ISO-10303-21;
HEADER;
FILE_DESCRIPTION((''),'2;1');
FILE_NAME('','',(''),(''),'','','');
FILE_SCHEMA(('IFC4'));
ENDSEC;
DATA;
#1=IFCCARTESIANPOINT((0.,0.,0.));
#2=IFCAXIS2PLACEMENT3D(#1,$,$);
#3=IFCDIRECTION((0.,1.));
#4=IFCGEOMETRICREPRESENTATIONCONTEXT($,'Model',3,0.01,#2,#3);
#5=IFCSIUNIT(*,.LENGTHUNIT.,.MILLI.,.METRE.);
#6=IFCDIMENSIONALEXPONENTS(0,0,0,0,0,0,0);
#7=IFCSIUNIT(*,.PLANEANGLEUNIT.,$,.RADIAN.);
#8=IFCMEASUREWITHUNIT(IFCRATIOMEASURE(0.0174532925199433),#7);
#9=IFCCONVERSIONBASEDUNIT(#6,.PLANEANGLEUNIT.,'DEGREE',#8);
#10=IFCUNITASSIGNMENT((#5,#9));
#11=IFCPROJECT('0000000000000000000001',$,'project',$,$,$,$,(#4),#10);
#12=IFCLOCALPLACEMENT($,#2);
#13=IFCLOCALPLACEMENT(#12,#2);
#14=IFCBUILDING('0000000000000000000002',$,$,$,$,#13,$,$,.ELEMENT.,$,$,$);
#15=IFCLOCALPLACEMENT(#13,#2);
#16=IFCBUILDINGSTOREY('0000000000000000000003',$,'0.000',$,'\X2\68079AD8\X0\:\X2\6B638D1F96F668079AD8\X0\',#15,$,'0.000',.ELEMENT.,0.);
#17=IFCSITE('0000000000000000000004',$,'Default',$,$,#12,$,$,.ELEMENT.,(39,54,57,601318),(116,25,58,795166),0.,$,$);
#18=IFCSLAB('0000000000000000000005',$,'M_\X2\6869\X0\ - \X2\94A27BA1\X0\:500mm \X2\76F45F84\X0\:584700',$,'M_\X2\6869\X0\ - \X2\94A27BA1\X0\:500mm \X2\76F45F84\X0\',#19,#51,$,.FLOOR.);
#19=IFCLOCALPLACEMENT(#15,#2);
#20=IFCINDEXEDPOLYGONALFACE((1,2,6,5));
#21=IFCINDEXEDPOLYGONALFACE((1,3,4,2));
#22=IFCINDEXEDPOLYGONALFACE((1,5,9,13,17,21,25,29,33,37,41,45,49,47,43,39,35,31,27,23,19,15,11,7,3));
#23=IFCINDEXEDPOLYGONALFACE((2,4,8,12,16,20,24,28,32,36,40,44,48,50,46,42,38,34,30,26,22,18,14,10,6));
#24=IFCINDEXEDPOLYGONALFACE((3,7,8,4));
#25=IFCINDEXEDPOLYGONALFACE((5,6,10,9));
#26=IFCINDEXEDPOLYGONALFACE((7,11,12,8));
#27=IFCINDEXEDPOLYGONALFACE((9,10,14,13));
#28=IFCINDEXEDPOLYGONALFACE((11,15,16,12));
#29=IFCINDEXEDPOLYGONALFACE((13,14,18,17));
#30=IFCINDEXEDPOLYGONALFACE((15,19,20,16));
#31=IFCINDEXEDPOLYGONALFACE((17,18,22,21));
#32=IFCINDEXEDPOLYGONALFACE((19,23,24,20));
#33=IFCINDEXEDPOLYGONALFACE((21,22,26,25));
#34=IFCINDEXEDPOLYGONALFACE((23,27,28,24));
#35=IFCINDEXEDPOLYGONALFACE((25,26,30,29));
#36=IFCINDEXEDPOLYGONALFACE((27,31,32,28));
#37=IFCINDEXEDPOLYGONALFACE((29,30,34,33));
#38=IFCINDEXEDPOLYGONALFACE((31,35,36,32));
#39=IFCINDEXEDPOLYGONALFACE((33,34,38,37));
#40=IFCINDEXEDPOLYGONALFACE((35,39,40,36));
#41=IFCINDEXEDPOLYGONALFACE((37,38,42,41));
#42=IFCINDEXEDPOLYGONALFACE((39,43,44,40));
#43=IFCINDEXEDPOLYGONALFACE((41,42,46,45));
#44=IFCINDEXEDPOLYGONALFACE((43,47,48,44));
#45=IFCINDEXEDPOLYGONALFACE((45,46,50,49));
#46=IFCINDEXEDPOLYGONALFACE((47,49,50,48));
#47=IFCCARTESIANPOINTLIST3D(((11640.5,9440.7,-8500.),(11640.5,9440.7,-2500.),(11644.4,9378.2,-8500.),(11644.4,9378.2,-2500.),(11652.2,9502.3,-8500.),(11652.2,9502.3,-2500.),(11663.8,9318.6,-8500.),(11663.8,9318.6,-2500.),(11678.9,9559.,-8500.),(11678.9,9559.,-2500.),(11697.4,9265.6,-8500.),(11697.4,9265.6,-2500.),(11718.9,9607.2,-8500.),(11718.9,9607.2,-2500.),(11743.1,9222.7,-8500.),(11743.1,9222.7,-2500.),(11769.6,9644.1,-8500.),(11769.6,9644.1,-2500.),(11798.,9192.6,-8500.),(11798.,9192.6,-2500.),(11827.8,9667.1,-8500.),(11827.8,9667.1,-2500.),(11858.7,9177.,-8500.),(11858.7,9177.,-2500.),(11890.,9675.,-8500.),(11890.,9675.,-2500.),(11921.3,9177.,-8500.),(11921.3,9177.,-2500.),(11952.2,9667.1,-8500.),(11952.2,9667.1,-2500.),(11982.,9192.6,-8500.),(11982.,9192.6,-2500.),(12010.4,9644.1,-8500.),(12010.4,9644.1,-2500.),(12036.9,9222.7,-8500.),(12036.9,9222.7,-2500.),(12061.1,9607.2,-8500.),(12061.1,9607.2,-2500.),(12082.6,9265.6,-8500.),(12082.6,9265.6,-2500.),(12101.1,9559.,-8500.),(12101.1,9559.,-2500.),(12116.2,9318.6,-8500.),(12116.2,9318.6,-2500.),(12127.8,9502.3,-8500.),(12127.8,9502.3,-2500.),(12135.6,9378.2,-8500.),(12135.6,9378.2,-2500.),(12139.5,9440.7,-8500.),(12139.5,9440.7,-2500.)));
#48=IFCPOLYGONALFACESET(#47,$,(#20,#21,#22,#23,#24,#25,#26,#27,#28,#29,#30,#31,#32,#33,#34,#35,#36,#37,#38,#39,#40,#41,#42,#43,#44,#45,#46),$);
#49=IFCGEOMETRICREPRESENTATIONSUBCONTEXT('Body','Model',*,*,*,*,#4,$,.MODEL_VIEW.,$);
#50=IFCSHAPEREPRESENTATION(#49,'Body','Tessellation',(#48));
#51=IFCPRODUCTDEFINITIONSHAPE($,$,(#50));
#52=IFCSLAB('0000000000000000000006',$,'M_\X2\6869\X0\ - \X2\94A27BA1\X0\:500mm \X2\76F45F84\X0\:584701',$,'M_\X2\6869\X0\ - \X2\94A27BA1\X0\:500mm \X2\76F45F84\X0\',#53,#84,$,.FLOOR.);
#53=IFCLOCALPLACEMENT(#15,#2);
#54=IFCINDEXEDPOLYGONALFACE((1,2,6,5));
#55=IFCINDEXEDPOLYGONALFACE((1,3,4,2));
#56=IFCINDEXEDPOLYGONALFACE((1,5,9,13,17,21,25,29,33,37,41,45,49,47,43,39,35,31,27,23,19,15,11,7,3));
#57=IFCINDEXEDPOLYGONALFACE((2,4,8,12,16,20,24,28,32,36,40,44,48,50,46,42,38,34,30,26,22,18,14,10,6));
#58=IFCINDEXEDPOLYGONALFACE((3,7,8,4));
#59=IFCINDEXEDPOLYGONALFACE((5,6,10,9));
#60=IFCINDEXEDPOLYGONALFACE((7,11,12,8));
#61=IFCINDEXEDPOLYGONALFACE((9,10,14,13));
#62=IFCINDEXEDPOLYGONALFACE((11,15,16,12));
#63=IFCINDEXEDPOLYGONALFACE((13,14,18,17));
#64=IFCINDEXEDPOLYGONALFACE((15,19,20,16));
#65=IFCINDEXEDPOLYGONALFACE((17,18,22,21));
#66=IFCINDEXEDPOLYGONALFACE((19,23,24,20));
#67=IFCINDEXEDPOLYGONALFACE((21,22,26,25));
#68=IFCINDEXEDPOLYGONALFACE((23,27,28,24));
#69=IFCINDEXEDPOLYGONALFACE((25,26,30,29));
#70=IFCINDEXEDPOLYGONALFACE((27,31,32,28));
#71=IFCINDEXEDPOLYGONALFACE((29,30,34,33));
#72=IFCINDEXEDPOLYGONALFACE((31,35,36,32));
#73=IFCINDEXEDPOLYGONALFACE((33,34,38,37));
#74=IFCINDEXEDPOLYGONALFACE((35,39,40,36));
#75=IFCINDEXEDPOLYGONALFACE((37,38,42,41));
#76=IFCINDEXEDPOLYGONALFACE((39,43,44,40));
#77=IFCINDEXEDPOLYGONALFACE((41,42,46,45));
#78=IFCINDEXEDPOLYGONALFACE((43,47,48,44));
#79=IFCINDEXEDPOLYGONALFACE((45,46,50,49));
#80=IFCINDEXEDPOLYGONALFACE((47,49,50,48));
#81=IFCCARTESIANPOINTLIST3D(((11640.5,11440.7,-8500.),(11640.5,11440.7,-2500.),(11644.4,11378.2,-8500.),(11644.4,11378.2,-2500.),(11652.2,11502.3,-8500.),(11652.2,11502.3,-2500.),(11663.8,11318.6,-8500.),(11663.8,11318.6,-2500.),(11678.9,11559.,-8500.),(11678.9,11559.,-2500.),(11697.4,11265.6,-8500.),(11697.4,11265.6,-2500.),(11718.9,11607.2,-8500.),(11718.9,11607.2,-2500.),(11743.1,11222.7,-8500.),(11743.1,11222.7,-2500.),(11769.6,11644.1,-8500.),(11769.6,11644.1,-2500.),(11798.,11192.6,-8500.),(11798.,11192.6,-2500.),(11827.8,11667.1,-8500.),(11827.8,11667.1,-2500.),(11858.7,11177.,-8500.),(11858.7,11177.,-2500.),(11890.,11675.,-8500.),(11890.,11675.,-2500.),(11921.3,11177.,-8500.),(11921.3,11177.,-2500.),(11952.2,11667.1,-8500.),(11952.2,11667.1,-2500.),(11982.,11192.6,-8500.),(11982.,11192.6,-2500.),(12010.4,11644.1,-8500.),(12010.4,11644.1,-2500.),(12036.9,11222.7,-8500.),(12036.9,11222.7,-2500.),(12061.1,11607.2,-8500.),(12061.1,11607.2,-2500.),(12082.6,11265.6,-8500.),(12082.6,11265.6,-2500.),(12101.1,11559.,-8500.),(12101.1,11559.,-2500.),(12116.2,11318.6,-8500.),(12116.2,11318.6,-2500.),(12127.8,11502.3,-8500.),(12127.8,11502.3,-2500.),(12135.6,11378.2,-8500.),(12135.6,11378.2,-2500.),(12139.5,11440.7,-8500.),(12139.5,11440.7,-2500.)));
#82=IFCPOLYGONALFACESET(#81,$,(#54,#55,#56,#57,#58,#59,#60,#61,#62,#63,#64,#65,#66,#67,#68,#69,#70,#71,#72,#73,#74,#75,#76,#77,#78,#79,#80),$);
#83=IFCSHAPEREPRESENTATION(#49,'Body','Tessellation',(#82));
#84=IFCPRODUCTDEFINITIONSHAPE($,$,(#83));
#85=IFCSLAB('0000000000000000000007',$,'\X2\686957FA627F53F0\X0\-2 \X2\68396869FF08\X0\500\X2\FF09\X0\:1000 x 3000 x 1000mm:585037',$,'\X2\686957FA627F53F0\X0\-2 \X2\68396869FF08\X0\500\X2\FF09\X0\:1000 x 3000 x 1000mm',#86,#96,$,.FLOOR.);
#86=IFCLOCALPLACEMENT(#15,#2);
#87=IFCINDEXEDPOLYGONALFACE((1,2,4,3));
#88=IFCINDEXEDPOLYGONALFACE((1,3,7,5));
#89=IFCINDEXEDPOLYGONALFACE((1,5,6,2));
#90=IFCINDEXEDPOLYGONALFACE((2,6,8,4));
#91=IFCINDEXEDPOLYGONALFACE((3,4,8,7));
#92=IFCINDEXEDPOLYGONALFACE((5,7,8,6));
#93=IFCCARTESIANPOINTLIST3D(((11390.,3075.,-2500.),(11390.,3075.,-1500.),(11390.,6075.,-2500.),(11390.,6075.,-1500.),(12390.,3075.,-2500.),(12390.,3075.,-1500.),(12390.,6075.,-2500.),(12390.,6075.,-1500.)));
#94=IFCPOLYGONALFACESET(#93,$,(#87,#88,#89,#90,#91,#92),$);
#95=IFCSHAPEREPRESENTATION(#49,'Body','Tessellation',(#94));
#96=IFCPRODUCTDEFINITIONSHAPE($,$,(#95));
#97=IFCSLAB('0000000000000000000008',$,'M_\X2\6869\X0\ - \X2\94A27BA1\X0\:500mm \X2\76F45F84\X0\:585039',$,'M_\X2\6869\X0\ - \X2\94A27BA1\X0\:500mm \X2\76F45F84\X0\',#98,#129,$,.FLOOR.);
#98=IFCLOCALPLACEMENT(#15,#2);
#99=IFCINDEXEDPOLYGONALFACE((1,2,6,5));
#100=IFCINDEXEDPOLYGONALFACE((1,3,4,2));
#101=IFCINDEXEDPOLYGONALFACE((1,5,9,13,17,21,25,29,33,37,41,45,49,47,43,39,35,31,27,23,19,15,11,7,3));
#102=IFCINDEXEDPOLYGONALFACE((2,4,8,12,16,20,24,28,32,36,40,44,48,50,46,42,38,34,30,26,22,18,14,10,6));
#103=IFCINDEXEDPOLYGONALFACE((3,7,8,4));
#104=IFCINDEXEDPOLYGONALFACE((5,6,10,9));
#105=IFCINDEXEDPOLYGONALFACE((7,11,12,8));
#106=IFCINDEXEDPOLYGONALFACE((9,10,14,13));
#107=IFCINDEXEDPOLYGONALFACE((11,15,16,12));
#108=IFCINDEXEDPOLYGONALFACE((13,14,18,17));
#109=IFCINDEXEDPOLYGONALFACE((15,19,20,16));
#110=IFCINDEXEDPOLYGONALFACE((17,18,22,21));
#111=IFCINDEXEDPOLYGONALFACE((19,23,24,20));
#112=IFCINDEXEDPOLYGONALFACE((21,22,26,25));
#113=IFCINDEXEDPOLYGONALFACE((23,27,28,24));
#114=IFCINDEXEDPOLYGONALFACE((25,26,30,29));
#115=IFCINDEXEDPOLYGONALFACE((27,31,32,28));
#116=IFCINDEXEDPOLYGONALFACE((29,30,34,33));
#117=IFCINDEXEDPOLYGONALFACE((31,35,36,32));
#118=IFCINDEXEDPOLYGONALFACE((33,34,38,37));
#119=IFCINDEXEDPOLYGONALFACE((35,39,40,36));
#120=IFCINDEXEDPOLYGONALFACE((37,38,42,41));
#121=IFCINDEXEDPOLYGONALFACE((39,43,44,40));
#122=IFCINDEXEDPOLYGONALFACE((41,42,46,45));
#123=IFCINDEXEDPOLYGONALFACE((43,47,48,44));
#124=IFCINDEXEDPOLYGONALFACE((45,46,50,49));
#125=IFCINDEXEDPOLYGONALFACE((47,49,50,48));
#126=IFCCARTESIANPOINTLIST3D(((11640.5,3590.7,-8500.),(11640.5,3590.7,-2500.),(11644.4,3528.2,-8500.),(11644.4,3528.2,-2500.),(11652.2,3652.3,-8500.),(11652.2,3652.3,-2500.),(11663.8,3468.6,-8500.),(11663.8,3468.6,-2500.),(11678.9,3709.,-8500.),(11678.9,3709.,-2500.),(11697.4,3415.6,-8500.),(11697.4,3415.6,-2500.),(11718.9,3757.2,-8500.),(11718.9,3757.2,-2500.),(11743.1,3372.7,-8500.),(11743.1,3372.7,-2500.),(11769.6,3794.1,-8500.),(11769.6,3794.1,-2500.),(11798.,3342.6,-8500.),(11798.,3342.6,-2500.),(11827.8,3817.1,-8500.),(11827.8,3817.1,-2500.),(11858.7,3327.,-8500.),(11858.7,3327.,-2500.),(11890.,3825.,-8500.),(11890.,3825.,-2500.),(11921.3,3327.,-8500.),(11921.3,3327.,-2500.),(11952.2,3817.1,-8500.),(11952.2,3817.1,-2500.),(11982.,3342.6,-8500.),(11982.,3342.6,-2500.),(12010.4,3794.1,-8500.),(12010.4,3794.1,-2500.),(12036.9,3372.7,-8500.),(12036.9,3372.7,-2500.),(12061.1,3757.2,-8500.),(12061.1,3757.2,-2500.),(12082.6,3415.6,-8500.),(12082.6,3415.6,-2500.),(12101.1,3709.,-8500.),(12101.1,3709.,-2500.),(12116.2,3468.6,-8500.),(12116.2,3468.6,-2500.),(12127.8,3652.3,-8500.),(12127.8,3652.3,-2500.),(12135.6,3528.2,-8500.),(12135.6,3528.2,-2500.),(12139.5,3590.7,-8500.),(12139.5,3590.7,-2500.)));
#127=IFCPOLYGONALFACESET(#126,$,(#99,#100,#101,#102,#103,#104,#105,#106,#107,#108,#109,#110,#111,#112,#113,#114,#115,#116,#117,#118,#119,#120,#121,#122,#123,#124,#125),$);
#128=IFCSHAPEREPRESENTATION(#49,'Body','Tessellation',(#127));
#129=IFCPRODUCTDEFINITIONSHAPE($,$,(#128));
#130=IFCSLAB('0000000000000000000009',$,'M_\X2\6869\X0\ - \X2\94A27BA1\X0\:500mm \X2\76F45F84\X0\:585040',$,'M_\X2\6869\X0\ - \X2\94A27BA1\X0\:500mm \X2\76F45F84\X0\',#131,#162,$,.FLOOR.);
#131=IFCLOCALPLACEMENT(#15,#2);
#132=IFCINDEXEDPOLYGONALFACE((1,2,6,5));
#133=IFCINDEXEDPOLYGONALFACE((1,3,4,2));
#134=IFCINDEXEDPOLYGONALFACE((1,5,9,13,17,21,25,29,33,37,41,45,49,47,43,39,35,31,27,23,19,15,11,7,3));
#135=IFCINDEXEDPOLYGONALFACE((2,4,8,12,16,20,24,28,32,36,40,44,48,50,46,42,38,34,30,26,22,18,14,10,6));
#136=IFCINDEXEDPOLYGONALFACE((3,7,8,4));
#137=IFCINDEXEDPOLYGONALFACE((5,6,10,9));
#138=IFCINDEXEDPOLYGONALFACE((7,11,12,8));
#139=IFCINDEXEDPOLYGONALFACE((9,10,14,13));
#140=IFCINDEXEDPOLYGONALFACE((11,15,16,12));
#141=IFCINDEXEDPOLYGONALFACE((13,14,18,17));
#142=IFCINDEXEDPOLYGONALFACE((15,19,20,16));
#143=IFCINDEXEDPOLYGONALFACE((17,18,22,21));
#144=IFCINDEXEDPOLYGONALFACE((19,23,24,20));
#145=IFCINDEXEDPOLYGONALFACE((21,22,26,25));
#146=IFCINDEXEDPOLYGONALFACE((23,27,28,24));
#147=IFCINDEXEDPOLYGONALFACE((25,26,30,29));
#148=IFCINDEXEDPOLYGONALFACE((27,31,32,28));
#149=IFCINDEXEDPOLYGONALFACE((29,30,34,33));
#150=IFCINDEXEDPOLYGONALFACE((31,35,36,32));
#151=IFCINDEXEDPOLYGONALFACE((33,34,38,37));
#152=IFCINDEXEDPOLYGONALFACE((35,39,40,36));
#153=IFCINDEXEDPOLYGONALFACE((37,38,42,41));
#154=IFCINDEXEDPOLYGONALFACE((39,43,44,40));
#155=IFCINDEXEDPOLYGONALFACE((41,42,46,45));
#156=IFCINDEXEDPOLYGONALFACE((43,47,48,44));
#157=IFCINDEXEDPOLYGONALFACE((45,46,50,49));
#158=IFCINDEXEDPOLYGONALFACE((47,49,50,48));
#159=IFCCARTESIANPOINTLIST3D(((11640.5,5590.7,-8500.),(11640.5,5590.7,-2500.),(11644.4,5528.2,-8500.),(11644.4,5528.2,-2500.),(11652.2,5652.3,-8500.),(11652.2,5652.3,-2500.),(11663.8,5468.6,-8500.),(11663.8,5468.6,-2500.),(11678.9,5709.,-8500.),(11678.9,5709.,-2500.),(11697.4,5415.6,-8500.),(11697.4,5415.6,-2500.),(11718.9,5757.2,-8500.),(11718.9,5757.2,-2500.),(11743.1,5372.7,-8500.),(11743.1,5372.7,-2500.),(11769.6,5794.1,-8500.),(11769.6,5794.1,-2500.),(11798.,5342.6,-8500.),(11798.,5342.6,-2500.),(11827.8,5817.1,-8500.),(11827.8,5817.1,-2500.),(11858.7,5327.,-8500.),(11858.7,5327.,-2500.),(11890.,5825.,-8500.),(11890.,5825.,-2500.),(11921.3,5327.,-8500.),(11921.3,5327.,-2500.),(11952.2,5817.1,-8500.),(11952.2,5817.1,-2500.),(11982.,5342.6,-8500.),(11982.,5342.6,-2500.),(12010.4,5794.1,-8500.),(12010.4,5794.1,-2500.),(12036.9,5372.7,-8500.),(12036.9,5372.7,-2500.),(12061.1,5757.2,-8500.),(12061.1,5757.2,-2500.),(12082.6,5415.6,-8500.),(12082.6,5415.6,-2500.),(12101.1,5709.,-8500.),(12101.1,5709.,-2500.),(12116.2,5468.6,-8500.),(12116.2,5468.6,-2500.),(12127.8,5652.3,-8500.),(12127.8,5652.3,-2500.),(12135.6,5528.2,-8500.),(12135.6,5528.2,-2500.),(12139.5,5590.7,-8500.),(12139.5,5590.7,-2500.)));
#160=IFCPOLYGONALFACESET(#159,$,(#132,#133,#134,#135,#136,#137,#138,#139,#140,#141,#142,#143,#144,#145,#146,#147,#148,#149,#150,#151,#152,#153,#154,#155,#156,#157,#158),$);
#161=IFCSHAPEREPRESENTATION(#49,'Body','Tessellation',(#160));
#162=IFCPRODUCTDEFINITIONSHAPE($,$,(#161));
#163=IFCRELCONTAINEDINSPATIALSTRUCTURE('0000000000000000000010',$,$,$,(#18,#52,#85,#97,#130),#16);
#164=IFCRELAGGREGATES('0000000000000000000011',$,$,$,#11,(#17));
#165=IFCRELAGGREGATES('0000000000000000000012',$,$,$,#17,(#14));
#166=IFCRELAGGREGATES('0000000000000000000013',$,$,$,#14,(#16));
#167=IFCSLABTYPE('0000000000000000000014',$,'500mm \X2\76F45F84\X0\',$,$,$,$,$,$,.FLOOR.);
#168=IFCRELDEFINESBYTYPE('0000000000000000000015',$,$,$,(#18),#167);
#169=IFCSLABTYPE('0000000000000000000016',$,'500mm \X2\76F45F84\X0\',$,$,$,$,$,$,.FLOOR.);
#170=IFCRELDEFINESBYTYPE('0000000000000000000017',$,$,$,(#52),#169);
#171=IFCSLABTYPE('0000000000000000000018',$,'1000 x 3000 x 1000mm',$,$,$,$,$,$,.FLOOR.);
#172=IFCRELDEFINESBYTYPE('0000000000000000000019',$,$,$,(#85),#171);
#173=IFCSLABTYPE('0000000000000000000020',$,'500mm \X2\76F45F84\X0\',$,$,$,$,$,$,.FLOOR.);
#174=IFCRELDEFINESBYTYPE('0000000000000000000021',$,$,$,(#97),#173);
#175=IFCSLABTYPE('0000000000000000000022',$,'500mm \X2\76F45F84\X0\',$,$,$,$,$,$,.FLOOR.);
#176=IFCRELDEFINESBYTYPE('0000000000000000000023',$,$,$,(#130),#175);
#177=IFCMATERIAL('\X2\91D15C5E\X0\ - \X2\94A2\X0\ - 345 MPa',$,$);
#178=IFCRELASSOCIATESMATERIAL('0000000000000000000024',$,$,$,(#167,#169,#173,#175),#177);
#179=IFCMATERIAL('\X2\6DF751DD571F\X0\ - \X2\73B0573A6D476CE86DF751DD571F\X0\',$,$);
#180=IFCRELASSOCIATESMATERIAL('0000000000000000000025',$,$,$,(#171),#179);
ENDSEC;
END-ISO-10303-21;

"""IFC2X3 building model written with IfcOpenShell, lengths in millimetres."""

from ifc_helpers import new_model, entity, si_unit, converted_unit, direction, frame, frame_2d, origin, origin_2d_with_axis, place, context, subcontext, project, spatial, rectangle, circle, extrude, material, type_object, element, save


model = new_model("IFC2X3")

# Units and contexts
model_context = context("Model", 3, precision=0.01, world=origin(), true_north=direction((0.0, 1.0)))
body_context = subcontext(model_context, "Body", "Model", "MODEL_VIEW")
ifc_project = project(units=[si_unit("LENGTHUNIT", "METRE", prefix="MILLI"), converted_unit("PLANEANGLEUNIT", "DEGREE", entity("IfcRatioMeasure", 0.0174532925199433), si_unit("PLANEANGLEUNIT", "RADIAN"), dimensions=[0, 0, 0, 0, 0, 0, 0])], contexts=[model_context])

# Site, building, storey
site_placement = place(None, origin())
site = spatial("IfcSite", under=ifc_project, at=site_placement, Name="Default", CompositionType="ELEMENT", RefLatitude=(39, 54, 57, 601318), RefLongitude=(116, 25, 58, 795166), RefElevation=0.0)
building_placement = place(site_placement, origin())
building = spatial("IfcBuilding", under=site, at=building_placement, CompositionType="ELEMENT")
storey_placement = place(building_placement, origin())
storey = spatial("IfcBuildingStorey", under=building, at=storey_placement, Name="0.000", ObjectType="标高:正负零标高", LongName="0.000", CompositionType="ELEMENT", Elevation=0.0)

# Slabs
ifc_material_1 = material(Name="金属 - 钢 - 345 MPa")
ifc_material_2 = material(Name="混凝土 - 现场浇注混凝土")
slab_type_1 = type_object("IfcSlabType", Name="500mm 直径", PredefinedType="FLOOR", material=ifc_material_1)
slab_1_placement = place(storey_placement, origin())
element("IfcSlab", 1, at=slab_1_placement, inside=storey, type_object=slab_type_1, Name="M_桩 - 钢管:500mm 直径:584700", ObjectType="M_桩 - 钢管:500mm 直径", PredefinedType="FLOOR", context=body_context, shape_type="SweptSolid", body=[
    extrude(circle(Radius=250.0, at=origin_2d_with_axis()), frame((11890.0, 9425.0, -8500.0), z_axis=(0.0, 0.0, 1.0), x_axis=(0.0, 1.0, 0.0)), (0.0, 0.0, 1.0), 6000.0),
])
slab_type_2 = type_object("IfcSlabType", Name="500mm 直径", PredefinedType="FLOOR", material=ifc_material_1)
slab_2_placement = place(storey_placement, origin())
element("IfcSlab", 2, at=slab_2_placement, inside=storey, type_object=slab_type_2, Name="M_桩 - 钢管:500mm 直径:584701", ObjectType="M_桩 - 钢管:500mm 直径", PredefinedType="FLOOR", context=body_context, shape_type="SweptSolid", body=[
    extrude(circle(Radius=250.0, at=origin_2d_with_axis()), frame((11890.0, 11425.0, -8500.0), z_axis=(0.0, 0.0, 1.0), x_axis=(0.0, 1.0, 0.0)), (0.0, 0.0, 1.0), 6000.0),
])
slab_type_3 = type_object("IfcSlabType", Name="1000 x 3000 x 1000mm", PredefinedType="FLOOR", material=ifc_material_2)
slab_3_placement = place(storey_placement, origin())
element("IfcSlab", 3, at=slab_3_placement, inside=storey, type_object=slab_type_3, Name="桩基承台-2 根桩（500）:1000 x 3000 x 1000mm:585037", ObjectType="桩基承台-2 根桩（500）:1000 x 3000 x 1000mm", PredefinedType="FLOOR", context=body_context, shape_type="SweptSolid", body=[
    extrude(rectangle(XDim=3000.0, YDim=1000.0, at=frame_2d((0.0, 0.0), x_axis=(1.0, 0.0))), frame((11890.0, 4575.0, -2500.0), z_axis=(0.0, 0.0, 1.0), x_axis=(0.0, -1.0, 0.0)), (0.0, 0.0, 1.0), 1000.0),
])
slab_type_4 = type_object("IfcSlabType", Name="500mm 直径", PredefinedType="FLOOR", material=ifc_material_1)
slab_4_placement = place(storey_placement, origin())
element("IfcSlab", 4, at=slab_4_placement, inside=storey, type_object=slab_type_4, Name="M_桩 - 钢管:500mm 直径:585039", ObjectType="M_桩 - 钢管:500mm 直径", PredefinedType="FLOOR", context=body_context, shape_type="SweptSolid", body=[
    extrude(circle(Radius=250.0, at=origin_2d_with_axis()), frame((11890.0, 3575.0, -8500.0), z_axis=(0.0, 0.0, 1.0), x_axis=(0.0, 1.0, 0.0)), (0.0, 0.0, 1.0), 6000.0),
])
slab_type_5 = type_object("IfcSlabType", Name="500mm 直径", PredefinedType="FLOOR", material=ifc_material_1)
slab_5_placement = place(storey_placement, origin())
element("IfcSlab", 5, at=slab_5_placement, inside=storey, type_object=slab_type_5, Name="M_桩 - 钢管:500mm 直径:585040", ObjectType="M_桩 - 钢管:500mm 直径", PredefinedType="FLOOR", context=body_context, shape_type="SweptSolid", body=[
    extrude(circle(Radius=250.0, at=origin_2d_with_axis()), frame((11890.0, 5575.0, -8500.0), z_axis=(0.0, 0.0, 1.0), x_axis=(0.0, 1.0, 0.0)), (0.0, 0.0, 1.0), 6000.0),
])

save(model, "model.ifc")
